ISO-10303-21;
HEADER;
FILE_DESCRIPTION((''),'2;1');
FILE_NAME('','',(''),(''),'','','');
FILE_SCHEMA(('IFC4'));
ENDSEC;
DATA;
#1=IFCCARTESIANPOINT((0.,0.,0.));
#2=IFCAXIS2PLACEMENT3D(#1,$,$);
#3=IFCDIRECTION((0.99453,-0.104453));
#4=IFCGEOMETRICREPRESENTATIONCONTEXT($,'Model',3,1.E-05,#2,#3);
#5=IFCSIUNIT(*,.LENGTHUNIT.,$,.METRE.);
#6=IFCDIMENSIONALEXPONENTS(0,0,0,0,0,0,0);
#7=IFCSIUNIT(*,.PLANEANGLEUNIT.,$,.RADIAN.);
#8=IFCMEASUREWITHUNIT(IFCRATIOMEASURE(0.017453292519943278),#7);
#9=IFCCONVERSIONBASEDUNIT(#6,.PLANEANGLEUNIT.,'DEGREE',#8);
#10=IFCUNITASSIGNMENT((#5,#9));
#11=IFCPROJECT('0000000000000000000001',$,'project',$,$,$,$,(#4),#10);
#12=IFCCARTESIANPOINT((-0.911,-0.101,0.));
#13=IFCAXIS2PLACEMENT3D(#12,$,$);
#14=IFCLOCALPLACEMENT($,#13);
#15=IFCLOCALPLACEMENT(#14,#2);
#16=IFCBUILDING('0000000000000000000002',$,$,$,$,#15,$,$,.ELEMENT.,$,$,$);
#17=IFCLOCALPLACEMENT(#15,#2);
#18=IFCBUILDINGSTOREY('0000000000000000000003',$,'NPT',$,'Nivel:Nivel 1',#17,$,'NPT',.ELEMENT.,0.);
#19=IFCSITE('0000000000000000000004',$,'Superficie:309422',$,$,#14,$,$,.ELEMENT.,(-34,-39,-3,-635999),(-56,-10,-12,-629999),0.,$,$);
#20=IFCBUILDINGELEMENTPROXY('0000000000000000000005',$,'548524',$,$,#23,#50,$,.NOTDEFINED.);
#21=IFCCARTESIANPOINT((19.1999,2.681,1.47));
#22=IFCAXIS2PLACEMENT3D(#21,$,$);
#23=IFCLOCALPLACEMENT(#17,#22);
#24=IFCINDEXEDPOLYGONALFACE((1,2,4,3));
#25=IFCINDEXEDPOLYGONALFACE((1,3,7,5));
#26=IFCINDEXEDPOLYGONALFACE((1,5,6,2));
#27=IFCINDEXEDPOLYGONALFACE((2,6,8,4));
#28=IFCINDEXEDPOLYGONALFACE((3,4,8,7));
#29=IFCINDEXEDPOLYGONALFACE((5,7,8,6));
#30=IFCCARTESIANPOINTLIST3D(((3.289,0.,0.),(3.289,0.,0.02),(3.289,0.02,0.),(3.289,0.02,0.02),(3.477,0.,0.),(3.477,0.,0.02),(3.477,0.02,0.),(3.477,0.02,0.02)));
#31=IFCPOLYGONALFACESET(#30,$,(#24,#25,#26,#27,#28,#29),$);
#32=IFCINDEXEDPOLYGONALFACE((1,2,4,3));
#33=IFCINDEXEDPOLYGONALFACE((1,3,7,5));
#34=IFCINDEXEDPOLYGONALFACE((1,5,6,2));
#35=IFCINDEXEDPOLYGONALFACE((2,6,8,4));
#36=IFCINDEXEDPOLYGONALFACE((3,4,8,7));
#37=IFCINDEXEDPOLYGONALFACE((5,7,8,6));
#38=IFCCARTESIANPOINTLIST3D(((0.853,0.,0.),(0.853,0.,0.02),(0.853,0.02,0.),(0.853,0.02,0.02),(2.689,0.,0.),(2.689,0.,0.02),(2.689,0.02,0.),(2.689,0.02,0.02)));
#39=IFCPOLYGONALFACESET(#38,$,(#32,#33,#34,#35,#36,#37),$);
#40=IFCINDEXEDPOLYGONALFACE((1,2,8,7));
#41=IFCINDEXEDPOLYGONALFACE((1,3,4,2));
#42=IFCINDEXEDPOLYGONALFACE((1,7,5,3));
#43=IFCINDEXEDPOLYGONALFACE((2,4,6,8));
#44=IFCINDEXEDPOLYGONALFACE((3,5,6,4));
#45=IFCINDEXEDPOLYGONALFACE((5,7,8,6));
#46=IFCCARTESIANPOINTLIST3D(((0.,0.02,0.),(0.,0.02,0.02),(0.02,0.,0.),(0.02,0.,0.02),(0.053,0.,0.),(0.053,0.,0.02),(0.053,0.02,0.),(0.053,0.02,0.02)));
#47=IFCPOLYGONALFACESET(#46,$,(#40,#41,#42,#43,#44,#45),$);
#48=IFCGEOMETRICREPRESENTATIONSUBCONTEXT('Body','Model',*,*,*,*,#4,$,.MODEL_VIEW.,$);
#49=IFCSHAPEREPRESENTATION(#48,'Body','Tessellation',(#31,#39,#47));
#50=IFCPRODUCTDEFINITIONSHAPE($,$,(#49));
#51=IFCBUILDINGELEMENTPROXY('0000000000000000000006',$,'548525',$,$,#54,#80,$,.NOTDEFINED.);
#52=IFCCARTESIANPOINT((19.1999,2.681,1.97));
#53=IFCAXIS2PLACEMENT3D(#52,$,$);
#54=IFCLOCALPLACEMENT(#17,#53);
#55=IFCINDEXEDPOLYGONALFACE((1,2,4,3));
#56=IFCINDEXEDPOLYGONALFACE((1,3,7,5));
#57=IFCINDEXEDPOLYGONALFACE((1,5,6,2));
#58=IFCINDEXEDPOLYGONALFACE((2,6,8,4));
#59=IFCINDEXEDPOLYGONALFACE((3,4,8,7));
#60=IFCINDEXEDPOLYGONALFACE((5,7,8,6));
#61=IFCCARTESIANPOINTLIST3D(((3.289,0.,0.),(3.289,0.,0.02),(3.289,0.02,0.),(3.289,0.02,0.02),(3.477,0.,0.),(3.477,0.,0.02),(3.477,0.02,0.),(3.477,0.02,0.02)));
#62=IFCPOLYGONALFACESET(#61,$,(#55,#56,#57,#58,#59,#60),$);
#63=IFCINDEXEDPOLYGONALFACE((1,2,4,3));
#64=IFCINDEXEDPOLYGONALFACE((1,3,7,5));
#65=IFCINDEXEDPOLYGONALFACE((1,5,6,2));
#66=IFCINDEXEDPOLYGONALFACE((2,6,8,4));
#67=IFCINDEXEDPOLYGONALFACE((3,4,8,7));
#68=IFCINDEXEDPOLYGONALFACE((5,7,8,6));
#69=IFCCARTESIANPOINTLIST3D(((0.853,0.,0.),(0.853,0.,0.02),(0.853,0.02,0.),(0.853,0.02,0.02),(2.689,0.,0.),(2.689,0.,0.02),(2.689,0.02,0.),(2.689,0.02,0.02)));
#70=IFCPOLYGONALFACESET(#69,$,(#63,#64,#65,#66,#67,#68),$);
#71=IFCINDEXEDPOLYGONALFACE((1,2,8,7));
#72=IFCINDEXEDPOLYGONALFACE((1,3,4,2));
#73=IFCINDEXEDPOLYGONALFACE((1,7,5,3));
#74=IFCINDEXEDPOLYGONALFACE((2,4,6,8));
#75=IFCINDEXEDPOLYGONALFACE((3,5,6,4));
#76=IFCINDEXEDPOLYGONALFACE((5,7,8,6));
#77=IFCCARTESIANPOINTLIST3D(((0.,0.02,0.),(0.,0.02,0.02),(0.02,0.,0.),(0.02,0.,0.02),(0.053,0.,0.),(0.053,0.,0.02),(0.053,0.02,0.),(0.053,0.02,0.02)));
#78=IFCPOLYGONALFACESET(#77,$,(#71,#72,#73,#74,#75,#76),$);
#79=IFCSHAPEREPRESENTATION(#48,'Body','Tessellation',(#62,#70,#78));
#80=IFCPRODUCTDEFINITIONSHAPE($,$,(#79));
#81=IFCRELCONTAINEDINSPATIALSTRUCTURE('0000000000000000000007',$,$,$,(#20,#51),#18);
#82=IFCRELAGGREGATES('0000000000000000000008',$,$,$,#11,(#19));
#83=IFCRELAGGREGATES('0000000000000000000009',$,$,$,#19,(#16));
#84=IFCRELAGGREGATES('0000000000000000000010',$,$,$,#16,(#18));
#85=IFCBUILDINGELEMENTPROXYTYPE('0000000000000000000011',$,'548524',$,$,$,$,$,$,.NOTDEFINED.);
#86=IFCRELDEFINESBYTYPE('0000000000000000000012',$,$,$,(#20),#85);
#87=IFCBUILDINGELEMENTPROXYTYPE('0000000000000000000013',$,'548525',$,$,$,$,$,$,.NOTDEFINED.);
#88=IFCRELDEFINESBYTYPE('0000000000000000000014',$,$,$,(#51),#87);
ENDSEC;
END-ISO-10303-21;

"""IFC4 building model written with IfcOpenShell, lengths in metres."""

from ifc_helpers import new_model, entity, si_unit, converted_unit, direction, frame, frame_2d, origin, place, context, subcontext, project, spatial, polyline, rectangle, outline, extrude, type_object, element, save


model = new_model("IFC4")

# Units and contexts
model_context = context("Model", 3, precision=1e-05, world=origin(), true_north=direction((0.99453, -0.104453)))
body_context = subcontext(model_context, "Body", "Model", "MODEL_VIEW")
ifc_project = project(units=[si_unit("LENGTHUNIT", "METRE"), converted_unit("PLANEANGLEUNIT", "DEGREE", entity("IfcRatioMeasure", 0.017453292519943278), si_unit("PLANEANGLEUNIT", "RADIAN"), dimensions=[0, 0, 0, 0, 0, 0, 0])], contexts=[model_context])

# Site, building, storey
site_placement = place(None, frame((-0.911, -0.101, 0.0)))
site = spatial("IfcSite", under=ifc_project, at=site_placement, Name="Superficie:309422", CompositionType="ELEMENT", RefLatitude=(-34, -39, -3, -635999), RefLongitude=(-56, -10, -12, -629999), RefElevation=0.0)
building_placement = place(site_placement, origin())
building = spatial("IfcBuilding", under=site, at=building_placement, CompositionType="ELEMENT")
storey_placement = place(building_placement, origin())
storey = spatial("IfcBuildingStorey", under=building, at=storey_placement, Name="NPT", ObjectType="Nivel:Nivel 1", LongName="NPT", CompositionType="ELEMENT", Elevation=0.0)

# Building element proxies
building_element_proxy_type_1 = type_object("IfcBuildingElementProxyType", Name="548524", PredefinedType="NOTDEFINED")
proxy_1_placement = place(storey_placement, frame((19.1999, 2.681, 1.47)))
element("IfcBuildingElementProxy", 1, at=proxy_1_placement, inside=storey, type_object=building_element_proxy_type_1, Name="548524", PredefinedType="NOTDEFINED", context=body_context, shape_type="SweptSolid", body=[
    extrude(rectangle(XDim=0.188, YDim=0.02, at=frame_2d((0.0263, 0.0), x_axis=(1.0, 0.0))), frame((3.4093, 0.01, 0.0), z_axis=(0.0, 0.0, 1.0), x_axis=(-1.0, 0.0, 0.0)), (0.0, 0.0, 1.0), 0.02),
    extrude(rectangle(XDim=1.836, YDim=0.02, at=frame_2d((0.0, 0.0), x_axis=(1.0, 0.0))), frame((1.771, 0.01, 0.0), z_axis=(0.0, 0.0, 1.0), x_axis=(-1.0, 0.0, 0.0)), (0.0, 0.0, 1.0), 0.02),
    extrude(outline(polyline([(-0.0215, -0.01), (0.0315, -0.01), (0.0115, 0.01), (-0.0215, 0.01), (-0.0215, -0.01)])), frame((0.0315, 0.01, 0.0), z_axis=(0.0, 0.0, 1.0), x_axis=(-1.0, 0.0, 0.0)), (0.0, 0.0, 1.0), 0.02),
])
building_element_proxy_type_2 = type_object("IfcBuildingElementProxyType", Name="548525", PredefinedType="NOTDEFINED")
proxy_2_placement = place(storey_placement, frame((19.1999, 2.681, 1.97)))
element("IfcBuildingElementProxy", 2, at=proxy_2_placement, inside=storey, type_object=building_element_proxy_type_2, Name="548525", PredefinedType="NOTDEFINED", context=body_context, shape_type="SweptSolid", body=[
    extrude(rectangle(XDim=0.188, YDim=0.02, at=frame_2d((0.0263, 0.0), x_axis=(1.0, 0.0))), frame((3.4093, 0.01, 0.0), z_axis=(0.0, 0.0, 1.0), x_axis=(-1.0, 0.0, 0.0)), (0.0, 0.0, 1.0), 0.02),
    extrude(rectangle(XDim=1.836, YDim=0.02, at=frame_2d((0.0, 0.0), x_axis=(1.0, 0.0))), frame((1.771, 0.01, 0.0), z_axis=(0.0, 0.0, 1.0), x_axis=(-1.0, 0.0, 0.0)), (0.0, 0.0, 1.0), 0.02),
    extrude(outline(polyline([(-0.0215, -0.01), (0.0315, -0.01), (0.0115, 0.01), (-0.0215, 0.01), (-0.0215, -0.01)])), frame((0.0315, 0.01, 0.0), z_axis=(0.0, 0.0, 1.0), x_axis=(-1.0, 0.0, 0.0)), (0.0, 0.0, 1.0), 0.02),
])

save(model, "model.ifc")
